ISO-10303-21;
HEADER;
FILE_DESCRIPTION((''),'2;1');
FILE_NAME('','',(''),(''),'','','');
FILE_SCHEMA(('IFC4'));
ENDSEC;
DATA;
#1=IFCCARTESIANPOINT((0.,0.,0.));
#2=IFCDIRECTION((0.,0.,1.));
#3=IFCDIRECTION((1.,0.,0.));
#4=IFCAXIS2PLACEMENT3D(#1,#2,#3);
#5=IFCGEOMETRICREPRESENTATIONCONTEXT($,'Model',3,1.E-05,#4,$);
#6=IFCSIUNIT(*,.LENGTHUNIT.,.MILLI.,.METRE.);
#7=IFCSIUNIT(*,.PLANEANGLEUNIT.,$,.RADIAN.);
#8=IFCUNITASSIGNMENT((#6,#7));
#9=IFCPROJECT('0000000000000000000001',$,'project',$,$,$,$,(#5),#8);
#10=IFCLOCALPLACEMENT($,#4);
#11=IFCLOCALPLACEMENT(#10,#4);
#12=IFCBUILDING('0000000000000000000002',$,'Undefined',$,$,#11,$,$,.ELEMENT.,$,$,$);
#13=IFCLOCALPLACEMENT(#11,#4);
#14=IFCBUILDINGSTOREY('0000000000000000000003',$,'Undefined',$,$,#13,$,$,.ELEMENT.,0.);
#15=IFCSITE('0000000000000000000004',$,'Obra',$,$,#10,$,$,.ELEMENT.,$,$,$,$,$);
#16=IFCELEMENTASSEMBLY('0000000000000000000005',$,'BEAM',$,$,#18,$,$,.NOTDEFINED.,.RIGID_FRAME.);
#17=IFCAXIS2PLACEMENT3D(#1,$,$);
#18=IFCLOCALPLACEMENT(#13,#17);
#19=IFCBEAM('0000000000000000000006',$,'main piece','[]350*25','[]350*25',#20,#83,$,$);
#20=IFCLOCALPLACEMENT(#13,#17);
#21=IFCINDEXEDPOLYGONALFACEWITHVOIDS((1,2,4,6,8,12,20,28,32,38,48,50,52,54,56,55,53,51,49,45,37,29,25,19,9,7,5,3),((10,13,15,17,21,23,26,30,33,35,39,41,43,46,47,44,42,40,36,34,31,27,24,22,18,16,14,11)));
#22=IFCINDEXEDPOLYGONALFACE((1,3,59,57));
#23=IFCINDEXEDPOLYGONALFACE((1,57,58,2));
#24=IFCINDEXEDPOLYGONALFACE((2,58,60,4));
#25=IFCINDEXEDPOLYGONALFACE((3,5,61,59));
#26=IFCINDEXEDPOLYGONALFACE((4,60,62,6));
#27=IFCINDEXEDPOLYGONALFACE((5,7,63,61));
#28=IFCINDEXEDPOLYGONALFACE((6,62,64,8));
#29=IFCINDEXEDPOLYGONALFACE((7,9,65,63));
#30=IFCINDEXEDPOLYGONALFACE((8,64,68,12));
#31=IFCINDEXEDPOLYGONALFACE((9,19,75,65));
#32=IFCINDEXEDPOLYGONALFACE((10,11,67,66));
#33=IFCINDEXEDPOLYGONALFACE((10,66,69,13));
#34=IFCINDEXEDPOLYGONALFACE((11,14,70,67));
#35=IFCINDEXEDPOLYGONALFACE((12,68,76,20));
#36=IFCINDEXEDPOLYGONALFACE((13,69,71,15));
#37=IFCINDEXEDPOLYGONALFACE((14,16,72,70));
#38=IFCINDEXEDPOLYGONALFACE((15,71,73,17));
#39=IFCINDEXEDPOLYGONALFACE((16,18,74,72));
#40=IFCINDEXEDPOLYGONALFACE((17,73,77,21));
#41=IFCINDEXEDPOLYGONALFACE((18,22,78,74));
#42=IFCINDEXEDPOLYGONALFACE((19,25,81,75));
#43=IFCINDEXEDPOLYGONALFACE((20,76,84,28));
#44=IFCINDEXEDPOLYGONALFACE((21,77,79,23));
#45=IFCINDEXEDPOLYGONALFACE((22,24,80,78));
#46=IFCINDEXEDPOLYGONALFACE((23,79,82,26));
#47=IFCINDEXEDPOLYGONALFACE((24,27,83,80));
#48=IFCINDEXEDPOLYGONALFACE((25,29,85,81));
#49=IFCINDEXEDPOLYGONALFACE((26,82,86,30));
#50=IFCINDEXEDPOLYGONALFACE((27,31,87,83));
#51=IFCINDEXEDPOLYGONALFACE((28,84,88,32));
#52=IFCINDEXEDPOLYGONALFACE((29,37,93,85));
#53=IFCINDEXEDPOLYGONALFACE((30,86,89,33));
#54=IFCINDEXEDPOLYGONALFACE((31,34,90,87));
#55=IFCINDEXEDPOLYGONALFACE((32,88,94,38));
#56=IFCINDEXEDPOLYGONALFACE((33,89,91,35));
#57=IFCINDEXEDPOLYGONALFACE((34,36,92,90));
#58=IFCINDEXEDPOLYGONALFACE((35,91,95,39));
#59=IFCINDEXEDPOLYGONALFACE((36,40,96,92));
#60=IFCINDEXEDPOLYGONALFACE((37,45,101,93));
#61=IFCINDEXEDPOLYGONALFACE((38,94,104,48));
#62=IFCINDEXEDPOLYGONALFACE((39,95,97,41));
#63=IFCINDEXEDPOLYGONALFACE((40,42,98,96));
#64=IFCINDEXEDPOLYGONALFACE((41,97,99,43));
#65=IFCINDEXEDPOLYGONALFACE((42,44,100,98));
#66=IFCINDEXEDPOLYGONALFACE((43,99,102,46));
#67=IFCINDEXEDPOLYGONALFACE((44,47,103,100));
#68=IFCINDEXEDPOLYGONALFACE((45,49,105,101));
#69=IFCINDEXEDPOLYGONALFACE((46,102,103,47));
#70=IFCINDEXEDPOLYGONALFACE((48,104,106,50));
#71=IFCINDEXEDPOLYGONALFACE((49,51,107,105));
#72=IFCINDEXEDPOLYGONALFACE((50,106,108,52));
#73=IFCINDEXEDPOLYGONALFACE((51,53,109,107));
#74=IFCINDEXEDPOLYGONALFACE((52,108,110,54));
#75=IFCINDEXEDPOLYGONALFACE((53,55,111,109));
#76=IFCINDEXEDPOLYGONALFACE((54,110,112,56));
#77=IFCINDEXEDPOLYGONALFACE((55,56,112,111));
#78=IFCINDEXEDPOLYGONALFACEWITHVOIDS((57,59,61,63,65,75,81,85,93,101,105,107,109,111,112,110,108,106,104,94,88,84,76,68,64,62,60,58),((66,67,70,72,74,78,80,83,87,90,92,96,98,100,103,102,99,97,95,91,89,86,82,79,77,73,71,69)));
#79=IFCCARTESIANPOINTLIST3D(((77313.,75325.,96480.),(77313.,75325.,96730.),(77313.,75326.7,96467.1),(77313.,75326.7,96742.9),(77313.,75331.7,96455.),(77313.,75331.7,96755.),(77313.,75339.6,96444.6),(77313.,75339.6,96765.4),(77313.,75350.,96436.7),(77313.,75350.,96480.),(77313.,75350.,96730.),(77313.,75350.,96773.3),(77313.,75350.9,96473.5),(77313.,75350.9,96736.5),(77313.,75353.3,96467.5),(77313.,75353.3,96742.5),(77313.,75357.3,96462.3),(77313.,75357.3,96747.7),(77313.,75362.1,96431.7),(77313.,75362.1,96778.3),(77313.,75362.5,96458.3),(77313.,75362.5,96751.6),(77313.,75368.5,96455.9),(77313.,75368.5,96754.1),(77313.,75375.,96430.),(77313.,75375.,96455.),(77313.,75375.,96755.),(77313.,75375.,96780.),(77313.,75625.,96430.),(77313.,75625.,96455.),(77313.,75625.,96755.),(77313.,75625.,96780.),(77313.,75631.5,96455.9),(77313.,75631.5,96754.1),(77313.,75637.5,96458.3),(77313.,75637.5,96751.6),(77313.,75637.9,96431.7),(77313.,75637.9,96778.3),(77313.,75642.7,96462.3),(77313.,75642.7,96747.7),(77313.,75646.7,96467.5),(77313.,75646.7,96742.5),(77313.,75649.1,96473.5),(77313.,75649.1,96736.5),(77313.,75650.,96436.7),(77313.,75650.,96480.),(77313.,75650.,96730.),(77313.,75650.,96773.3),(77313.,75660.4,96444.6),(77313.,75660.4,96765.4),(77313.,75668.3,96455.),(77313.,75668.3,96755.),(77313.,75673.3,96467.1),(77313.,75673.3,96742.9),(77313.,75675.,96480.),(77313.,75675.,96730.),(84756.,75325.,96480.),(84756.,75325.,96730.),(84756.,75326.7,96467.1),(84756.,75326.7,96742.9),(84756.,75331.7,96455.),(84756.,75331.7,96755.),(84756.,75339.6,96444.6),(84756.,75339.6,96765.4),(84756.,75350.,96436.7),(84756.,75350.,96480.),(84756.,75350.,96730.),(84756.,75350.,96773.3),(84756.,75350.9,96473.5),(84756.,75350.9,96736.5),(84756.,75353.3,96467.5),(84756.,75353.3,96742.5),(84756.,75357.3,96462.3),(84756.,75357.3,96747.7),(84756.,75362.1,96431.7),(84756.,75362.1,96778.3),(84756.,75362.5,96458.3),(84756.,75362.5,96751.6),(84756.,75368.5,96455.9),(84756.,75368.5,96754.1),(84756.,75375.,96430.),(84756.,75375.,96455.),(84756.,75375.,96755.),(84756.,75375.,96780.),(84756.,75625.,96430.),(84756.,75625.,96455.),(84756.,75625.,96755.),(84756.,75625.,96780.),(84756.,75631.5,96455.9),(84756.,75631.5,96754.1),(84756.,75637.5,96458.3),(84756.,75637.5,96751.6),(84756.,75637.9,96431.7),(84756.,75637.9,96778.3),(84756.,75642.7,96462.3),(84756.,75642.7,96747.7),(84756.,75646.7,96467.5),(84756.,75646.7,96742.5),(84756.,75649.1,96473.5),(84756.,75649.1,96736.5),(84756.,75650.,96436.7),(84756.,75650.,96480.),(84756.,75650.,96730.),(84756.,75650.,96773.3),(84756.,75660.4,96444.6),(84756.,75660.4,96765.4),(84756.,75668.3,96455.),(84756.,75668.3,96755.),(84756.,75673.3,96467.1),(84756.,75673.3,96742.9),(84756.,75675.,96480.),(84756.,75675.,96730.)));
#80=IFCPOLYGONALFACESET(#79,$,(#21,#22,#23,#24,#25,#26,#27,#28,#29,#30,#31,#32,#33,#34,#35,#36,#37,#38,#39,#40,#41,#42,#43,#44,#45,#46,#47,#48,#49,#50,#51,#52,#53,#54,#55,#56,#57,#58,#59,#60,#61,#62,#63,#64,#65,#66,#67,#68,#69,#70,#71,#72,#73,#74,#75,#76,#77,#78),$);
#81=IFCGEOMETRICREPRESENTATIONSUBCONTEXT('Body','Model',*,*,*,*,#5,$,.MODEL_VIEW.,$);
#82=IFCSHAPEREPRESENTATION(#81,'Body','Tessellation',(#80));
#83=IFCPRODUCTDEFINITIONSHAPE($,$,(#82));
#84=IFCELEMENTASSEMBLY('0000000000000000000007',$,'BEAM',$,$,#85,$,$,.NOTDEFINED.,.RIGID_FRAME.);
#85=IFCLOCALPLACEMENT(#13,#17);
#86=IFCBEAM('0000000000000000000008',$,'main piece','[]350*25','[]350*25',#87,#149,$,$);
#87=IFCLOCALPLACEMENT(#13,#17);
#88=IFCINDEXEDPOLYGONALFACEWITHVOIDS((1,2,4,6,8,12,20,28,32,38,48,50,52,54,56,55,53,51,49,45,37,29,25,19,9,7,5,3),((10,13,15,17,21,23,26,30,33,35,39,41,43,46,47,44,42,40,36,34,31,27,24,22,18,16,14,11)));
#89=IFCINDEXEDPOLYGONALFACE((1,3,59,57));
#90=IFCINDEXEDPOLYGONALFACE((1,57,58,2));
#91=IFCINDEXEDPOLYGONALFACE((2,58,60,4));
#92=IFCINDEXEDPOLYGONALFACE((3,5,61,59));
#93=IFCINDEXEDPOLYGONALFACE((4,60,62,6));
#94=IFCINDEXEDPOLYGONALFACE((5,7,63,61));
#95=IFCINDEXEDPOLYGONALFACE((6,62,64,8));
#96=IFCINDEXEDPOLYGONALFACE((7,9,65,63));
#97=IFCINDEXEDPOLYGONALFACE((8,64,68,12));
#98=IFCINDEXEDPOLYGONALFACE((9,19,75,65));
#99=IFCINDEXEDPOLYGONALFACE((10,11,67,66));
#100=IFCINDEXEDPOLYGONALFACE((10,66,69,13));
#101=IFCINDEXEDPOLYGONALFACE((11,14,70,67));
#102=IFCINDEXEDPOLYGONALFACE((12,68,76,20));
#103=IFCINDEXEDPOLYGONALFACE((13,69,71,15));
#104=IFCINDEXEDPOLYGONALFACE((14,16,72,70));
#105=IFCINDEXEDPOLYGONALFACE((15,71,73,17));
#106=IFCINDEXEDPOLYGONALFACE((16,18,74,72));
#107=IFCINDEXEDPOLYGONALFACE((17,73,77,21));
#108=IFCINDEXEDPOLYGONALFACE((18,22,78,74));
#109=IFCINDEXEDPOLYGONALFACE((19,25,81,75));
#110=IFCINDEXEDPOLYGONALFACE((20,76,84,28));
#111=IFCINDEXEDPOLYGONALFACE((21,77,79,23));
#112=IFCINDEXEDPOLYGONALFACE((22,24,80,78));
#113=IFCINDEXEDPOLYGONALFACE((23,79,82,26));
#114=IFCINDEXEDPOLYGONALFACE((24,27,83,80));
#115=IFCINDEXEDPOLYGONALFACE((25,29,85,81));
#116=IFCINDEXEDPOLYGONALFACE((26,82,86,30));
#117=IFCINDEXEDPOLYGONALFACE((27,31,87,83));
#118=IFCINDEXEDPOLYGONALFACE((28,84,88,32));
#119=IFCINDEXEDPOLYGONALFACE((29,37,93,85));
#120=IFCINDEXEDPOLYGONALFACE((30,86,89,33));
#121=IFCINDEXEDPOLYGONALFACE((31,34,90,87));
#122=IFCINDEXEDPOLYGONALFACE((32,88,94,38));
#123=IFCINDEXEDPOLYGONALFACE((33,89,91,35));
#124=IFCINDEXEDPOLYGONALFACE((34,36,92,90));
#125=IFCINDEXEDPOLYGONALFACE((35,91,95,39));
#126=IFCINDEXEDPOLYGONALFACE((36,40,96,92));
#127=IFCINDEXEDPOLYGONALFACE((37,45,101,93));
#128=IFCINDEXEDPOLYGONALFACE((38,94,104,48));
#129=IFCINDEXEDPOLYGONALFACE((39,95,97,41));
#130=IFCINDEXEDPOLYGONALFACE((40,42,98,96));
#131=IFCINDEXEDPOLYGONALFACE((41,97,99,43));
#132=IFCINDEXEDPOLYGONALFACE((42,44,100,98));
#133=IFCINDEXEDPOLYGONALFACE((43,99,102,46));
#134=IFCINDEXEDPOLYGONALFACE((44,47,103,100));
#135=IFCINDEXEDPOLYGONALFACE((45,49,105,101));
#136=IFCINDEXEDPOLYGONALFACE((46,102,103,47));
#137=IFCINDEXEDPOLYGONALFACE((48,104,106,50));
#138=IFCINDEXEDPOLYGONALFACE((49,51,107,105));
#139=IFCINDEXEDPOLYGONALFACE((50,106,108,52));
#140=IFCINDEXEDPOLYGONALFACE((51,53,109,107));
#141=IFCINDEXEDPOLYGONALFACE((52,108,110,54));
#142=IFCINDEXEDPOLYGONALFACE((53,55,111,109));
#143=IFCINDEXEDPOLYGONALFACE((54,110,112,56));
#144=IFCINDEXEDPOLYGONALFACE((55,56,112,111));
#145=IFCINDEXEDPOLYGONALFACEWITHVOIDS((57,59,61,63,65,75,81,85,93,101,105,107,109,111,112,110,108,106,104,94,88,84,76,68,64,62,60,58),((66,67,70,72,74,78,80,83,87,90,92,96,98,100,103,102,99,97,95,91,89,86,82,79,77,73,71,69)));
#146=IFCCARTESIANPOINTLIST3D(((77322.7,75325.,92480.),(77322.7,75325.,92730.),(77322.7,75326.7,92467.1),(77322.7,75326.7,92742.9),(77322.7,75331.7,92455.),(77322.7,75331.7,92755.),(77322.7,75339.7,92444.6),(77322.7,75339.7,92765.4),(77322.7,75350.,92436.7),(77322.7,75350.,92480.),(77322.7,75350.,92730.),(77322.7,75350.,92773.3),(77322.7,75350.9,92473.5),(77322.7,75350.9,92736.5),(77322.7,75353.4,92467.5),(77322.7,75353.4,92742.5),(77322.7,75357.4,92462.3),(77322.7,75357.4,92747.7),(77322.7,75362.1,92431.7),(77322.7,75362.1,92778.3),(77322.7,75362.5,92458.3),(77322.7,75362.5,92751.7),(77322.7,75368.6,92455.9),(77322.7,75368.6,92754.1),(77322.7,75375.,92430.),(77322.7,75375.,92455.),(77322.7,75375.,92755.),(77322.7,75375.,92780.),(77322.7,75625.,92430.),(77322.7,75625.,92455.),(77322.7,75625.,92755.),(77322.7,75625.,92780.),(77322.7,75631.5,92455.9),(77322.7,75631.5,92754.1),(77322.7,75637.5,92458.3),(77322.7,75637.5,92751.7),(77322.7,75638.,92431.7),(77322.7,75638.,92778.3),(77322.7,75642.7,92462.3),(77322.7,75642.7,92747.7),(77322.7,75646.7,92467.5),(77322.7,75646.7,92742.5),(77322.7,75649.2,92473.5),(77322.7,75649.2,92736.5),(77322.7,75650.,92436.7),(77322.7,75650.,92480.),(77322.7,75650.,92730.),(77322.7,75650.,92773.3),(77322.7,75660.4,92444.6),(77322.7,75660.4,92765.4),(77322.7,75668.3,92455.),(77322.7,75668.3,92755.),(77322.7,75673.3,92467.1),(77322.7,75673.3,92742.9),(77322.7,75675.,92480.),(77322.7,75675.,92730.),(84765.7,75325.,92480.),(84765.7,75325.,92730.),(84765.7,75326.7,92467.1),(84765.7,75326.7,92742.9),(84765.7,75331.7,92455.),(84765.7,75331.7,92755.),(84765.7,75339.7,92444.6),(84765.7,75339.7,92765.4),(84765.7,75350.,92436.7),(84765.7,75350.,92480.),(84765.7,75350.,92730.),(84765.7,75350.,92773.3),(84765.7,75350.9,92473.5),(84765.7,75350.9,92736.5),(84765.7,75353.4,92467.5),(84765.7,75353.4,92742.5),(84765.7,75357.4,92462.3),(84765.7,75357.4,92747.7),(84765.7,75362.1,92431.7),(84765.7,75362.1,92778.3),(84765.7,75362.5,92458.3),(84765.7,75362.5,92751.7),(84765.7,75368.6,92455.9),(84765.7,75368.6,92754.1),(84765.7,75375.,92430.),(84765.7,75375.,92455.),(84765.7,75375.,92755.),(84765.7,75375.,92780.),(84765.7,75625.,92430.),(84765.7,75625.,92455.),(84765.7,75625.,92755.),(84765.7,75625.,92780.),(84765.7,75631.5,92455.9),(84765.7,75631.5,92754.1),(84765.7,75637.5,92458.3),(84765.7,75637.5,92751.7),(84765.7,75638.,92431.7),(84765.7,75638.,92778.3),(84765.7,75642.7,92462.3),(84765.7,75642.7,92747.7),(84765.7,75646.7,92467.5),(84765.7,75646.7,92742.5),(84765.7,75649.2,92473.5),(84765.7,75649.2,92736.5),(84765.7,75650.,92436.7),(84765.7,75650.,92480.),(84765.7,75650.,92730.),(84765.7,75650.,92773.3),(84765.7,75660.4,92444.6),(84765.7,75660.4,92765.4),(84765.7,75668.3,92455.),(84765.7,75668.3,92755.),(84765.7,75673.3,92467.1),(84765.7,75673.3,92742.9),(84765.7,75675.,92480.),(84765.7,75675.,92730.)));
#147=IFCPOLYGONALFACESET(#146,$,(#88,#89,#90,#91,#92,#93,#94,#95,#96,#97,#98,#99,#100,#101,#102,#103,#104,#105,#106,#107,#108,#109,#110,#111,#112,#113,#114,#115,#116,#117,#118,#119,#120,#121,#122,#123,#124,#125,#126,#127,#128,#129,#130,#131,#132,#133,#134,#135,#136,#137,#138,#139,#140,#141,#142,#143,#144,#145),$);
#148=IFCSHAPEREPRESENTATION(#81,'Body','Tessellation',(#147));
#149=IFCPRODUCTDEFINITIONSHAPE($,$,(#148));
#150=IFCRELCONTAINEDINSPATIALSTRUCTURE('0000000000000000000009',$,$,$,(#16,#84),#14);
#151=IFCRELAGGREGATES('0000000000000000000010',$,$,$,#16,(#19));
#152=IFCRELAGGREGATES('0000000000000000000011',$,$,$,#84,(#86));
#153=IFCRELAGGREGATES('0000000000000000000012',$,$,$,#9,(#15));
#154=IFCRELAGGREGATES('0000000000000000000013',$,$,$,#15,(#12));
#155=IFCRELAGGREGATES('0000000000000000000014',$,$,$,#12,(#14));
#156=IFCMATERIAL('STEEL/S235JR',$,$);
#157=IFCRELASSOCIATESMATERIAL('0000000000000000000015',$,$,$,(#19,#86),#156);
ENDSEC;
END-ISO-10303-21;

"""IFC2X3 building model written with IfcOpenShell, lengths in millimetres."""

from ifc_helpers import new_model, si_unit, frame, origin_with_axes, origin_2d_with_axis, place, context, subcontext, project, spatial, hollow_rectangle, extrude, material, element, aggregate, save


model = new_model("IFC2X3")

# Units and contexts
model_context = context("Model", 3, precision=1e-05, world=origin_with_axes())
body_context = subcontext(model_context, "Body", "Model", "MODEL_VIEW")
ifc_project = project(units=[si_unit("LENGTHUNIT", "METRE", prefix="MILLI"), si_unit("PLANEANGLEUNIT", "RADIAN")], contexts=[model_context])

# Site, building, storey
site_placement = place(None, origin_with_axes())
site = spatial("IfcSite", under=ifc_project, at=site_placement, Name="Obra", CompositionType="ELEMENT")
building_placement = place(site_placement, origin_with_axes())
building = spatial("IfcBuilding", under=site, at=building_placement, Name="Undefined", CompositionType="ELEMENT")
storey_placement = place(building_placement, origin_with_axes())
storey = spatial("IfcBuildingStorey", under=building, at=storey_placement, Name="Undefined", CompositionType="ELEMENT", Elevation=0.0)

# Shared definitions
ifc_material = material(Name="STEEL/S235JR")

# Element assemblies, beams
assembly_1_placement = place(storey_placement, origin_with_axes())
assembly_1 = element("IfcElementAssembly", 1, at=assembly_1_placement, inside=storey, Name="BEAM", AssemblyPlace="NOTDEFINED", PredefinedType="RIGID_FRAME")
beam_1_placement = place(assembly_1_placement, frame((84756.0, 75500.0, 96605.0), z_axis=(0.0, 0.0, 1.0), x_axis=(-1.0, 0.0, 0.0)))
beam_1 = element("IfcBeam", 2, at=beam_1_placement, material=ifc_material, Name="main piece", Description="[]350*25", ObjectType="[]350*25", context=body_context, shape_type="SweptSolid", body=[
    extrude(hollow_rectangle(XDim=350.0, YDim=350.0, WallThickness=25.0, InnerFilletRadius=25.0, OuterFilletRadius=50.0, at=origin_2d_with_axis()), frame((7443.0, 0.0, 0.0), z_axis=(-1.0, 0.0, 0.0), x_axis=(0.0, -1.0, 0.0)), (0.0, 0.0, 1.0), 7443.0),
])
aggregate(assembly_1, [beam_1])
assembly_2_placement = place(storey_placement, origin_with_axes())
assembly_2 = element("IfcElementAssembly", 3, at=assembly_2_placement, inside=storey, Name="BEAM", AssemblyPlace="NOTDEFINED", PredefinedType="RIGID_FRAME")
beam_2_placement = place(assembly_2_placement, frame((84765.7, 75500.0, 92605.0), z_axis=(0.0, 0.0, 1.0), x_axis=(-1.0, 0.0, 0.0)))
beam_2 = element("IfcBeam", 4, at=beam_2_placement, material=ifc_material, Name="main piece", Description="[]350*25", ObjectType="[]350*25", context=body_context, shape_type="SweptSolid", body=[
    extrude(hollow_rectangle(XDim=350.0, YDim=350.0, WallThickness=25.0, InnerFilletRadius=25.0, OuterFilletRadius=50.0, at=origin_2d_with_axis()), frame((7443.0, 0.0, 0.0), z_axis=(-1.0, 0.0, 0.0), x_axis=(0.0, -1.0, 0.0)), (0.0, 0.0, 1.0), 7443.0),
])
aggregate(assembly_2, [beam_2])

save(model, "model.ifc")
